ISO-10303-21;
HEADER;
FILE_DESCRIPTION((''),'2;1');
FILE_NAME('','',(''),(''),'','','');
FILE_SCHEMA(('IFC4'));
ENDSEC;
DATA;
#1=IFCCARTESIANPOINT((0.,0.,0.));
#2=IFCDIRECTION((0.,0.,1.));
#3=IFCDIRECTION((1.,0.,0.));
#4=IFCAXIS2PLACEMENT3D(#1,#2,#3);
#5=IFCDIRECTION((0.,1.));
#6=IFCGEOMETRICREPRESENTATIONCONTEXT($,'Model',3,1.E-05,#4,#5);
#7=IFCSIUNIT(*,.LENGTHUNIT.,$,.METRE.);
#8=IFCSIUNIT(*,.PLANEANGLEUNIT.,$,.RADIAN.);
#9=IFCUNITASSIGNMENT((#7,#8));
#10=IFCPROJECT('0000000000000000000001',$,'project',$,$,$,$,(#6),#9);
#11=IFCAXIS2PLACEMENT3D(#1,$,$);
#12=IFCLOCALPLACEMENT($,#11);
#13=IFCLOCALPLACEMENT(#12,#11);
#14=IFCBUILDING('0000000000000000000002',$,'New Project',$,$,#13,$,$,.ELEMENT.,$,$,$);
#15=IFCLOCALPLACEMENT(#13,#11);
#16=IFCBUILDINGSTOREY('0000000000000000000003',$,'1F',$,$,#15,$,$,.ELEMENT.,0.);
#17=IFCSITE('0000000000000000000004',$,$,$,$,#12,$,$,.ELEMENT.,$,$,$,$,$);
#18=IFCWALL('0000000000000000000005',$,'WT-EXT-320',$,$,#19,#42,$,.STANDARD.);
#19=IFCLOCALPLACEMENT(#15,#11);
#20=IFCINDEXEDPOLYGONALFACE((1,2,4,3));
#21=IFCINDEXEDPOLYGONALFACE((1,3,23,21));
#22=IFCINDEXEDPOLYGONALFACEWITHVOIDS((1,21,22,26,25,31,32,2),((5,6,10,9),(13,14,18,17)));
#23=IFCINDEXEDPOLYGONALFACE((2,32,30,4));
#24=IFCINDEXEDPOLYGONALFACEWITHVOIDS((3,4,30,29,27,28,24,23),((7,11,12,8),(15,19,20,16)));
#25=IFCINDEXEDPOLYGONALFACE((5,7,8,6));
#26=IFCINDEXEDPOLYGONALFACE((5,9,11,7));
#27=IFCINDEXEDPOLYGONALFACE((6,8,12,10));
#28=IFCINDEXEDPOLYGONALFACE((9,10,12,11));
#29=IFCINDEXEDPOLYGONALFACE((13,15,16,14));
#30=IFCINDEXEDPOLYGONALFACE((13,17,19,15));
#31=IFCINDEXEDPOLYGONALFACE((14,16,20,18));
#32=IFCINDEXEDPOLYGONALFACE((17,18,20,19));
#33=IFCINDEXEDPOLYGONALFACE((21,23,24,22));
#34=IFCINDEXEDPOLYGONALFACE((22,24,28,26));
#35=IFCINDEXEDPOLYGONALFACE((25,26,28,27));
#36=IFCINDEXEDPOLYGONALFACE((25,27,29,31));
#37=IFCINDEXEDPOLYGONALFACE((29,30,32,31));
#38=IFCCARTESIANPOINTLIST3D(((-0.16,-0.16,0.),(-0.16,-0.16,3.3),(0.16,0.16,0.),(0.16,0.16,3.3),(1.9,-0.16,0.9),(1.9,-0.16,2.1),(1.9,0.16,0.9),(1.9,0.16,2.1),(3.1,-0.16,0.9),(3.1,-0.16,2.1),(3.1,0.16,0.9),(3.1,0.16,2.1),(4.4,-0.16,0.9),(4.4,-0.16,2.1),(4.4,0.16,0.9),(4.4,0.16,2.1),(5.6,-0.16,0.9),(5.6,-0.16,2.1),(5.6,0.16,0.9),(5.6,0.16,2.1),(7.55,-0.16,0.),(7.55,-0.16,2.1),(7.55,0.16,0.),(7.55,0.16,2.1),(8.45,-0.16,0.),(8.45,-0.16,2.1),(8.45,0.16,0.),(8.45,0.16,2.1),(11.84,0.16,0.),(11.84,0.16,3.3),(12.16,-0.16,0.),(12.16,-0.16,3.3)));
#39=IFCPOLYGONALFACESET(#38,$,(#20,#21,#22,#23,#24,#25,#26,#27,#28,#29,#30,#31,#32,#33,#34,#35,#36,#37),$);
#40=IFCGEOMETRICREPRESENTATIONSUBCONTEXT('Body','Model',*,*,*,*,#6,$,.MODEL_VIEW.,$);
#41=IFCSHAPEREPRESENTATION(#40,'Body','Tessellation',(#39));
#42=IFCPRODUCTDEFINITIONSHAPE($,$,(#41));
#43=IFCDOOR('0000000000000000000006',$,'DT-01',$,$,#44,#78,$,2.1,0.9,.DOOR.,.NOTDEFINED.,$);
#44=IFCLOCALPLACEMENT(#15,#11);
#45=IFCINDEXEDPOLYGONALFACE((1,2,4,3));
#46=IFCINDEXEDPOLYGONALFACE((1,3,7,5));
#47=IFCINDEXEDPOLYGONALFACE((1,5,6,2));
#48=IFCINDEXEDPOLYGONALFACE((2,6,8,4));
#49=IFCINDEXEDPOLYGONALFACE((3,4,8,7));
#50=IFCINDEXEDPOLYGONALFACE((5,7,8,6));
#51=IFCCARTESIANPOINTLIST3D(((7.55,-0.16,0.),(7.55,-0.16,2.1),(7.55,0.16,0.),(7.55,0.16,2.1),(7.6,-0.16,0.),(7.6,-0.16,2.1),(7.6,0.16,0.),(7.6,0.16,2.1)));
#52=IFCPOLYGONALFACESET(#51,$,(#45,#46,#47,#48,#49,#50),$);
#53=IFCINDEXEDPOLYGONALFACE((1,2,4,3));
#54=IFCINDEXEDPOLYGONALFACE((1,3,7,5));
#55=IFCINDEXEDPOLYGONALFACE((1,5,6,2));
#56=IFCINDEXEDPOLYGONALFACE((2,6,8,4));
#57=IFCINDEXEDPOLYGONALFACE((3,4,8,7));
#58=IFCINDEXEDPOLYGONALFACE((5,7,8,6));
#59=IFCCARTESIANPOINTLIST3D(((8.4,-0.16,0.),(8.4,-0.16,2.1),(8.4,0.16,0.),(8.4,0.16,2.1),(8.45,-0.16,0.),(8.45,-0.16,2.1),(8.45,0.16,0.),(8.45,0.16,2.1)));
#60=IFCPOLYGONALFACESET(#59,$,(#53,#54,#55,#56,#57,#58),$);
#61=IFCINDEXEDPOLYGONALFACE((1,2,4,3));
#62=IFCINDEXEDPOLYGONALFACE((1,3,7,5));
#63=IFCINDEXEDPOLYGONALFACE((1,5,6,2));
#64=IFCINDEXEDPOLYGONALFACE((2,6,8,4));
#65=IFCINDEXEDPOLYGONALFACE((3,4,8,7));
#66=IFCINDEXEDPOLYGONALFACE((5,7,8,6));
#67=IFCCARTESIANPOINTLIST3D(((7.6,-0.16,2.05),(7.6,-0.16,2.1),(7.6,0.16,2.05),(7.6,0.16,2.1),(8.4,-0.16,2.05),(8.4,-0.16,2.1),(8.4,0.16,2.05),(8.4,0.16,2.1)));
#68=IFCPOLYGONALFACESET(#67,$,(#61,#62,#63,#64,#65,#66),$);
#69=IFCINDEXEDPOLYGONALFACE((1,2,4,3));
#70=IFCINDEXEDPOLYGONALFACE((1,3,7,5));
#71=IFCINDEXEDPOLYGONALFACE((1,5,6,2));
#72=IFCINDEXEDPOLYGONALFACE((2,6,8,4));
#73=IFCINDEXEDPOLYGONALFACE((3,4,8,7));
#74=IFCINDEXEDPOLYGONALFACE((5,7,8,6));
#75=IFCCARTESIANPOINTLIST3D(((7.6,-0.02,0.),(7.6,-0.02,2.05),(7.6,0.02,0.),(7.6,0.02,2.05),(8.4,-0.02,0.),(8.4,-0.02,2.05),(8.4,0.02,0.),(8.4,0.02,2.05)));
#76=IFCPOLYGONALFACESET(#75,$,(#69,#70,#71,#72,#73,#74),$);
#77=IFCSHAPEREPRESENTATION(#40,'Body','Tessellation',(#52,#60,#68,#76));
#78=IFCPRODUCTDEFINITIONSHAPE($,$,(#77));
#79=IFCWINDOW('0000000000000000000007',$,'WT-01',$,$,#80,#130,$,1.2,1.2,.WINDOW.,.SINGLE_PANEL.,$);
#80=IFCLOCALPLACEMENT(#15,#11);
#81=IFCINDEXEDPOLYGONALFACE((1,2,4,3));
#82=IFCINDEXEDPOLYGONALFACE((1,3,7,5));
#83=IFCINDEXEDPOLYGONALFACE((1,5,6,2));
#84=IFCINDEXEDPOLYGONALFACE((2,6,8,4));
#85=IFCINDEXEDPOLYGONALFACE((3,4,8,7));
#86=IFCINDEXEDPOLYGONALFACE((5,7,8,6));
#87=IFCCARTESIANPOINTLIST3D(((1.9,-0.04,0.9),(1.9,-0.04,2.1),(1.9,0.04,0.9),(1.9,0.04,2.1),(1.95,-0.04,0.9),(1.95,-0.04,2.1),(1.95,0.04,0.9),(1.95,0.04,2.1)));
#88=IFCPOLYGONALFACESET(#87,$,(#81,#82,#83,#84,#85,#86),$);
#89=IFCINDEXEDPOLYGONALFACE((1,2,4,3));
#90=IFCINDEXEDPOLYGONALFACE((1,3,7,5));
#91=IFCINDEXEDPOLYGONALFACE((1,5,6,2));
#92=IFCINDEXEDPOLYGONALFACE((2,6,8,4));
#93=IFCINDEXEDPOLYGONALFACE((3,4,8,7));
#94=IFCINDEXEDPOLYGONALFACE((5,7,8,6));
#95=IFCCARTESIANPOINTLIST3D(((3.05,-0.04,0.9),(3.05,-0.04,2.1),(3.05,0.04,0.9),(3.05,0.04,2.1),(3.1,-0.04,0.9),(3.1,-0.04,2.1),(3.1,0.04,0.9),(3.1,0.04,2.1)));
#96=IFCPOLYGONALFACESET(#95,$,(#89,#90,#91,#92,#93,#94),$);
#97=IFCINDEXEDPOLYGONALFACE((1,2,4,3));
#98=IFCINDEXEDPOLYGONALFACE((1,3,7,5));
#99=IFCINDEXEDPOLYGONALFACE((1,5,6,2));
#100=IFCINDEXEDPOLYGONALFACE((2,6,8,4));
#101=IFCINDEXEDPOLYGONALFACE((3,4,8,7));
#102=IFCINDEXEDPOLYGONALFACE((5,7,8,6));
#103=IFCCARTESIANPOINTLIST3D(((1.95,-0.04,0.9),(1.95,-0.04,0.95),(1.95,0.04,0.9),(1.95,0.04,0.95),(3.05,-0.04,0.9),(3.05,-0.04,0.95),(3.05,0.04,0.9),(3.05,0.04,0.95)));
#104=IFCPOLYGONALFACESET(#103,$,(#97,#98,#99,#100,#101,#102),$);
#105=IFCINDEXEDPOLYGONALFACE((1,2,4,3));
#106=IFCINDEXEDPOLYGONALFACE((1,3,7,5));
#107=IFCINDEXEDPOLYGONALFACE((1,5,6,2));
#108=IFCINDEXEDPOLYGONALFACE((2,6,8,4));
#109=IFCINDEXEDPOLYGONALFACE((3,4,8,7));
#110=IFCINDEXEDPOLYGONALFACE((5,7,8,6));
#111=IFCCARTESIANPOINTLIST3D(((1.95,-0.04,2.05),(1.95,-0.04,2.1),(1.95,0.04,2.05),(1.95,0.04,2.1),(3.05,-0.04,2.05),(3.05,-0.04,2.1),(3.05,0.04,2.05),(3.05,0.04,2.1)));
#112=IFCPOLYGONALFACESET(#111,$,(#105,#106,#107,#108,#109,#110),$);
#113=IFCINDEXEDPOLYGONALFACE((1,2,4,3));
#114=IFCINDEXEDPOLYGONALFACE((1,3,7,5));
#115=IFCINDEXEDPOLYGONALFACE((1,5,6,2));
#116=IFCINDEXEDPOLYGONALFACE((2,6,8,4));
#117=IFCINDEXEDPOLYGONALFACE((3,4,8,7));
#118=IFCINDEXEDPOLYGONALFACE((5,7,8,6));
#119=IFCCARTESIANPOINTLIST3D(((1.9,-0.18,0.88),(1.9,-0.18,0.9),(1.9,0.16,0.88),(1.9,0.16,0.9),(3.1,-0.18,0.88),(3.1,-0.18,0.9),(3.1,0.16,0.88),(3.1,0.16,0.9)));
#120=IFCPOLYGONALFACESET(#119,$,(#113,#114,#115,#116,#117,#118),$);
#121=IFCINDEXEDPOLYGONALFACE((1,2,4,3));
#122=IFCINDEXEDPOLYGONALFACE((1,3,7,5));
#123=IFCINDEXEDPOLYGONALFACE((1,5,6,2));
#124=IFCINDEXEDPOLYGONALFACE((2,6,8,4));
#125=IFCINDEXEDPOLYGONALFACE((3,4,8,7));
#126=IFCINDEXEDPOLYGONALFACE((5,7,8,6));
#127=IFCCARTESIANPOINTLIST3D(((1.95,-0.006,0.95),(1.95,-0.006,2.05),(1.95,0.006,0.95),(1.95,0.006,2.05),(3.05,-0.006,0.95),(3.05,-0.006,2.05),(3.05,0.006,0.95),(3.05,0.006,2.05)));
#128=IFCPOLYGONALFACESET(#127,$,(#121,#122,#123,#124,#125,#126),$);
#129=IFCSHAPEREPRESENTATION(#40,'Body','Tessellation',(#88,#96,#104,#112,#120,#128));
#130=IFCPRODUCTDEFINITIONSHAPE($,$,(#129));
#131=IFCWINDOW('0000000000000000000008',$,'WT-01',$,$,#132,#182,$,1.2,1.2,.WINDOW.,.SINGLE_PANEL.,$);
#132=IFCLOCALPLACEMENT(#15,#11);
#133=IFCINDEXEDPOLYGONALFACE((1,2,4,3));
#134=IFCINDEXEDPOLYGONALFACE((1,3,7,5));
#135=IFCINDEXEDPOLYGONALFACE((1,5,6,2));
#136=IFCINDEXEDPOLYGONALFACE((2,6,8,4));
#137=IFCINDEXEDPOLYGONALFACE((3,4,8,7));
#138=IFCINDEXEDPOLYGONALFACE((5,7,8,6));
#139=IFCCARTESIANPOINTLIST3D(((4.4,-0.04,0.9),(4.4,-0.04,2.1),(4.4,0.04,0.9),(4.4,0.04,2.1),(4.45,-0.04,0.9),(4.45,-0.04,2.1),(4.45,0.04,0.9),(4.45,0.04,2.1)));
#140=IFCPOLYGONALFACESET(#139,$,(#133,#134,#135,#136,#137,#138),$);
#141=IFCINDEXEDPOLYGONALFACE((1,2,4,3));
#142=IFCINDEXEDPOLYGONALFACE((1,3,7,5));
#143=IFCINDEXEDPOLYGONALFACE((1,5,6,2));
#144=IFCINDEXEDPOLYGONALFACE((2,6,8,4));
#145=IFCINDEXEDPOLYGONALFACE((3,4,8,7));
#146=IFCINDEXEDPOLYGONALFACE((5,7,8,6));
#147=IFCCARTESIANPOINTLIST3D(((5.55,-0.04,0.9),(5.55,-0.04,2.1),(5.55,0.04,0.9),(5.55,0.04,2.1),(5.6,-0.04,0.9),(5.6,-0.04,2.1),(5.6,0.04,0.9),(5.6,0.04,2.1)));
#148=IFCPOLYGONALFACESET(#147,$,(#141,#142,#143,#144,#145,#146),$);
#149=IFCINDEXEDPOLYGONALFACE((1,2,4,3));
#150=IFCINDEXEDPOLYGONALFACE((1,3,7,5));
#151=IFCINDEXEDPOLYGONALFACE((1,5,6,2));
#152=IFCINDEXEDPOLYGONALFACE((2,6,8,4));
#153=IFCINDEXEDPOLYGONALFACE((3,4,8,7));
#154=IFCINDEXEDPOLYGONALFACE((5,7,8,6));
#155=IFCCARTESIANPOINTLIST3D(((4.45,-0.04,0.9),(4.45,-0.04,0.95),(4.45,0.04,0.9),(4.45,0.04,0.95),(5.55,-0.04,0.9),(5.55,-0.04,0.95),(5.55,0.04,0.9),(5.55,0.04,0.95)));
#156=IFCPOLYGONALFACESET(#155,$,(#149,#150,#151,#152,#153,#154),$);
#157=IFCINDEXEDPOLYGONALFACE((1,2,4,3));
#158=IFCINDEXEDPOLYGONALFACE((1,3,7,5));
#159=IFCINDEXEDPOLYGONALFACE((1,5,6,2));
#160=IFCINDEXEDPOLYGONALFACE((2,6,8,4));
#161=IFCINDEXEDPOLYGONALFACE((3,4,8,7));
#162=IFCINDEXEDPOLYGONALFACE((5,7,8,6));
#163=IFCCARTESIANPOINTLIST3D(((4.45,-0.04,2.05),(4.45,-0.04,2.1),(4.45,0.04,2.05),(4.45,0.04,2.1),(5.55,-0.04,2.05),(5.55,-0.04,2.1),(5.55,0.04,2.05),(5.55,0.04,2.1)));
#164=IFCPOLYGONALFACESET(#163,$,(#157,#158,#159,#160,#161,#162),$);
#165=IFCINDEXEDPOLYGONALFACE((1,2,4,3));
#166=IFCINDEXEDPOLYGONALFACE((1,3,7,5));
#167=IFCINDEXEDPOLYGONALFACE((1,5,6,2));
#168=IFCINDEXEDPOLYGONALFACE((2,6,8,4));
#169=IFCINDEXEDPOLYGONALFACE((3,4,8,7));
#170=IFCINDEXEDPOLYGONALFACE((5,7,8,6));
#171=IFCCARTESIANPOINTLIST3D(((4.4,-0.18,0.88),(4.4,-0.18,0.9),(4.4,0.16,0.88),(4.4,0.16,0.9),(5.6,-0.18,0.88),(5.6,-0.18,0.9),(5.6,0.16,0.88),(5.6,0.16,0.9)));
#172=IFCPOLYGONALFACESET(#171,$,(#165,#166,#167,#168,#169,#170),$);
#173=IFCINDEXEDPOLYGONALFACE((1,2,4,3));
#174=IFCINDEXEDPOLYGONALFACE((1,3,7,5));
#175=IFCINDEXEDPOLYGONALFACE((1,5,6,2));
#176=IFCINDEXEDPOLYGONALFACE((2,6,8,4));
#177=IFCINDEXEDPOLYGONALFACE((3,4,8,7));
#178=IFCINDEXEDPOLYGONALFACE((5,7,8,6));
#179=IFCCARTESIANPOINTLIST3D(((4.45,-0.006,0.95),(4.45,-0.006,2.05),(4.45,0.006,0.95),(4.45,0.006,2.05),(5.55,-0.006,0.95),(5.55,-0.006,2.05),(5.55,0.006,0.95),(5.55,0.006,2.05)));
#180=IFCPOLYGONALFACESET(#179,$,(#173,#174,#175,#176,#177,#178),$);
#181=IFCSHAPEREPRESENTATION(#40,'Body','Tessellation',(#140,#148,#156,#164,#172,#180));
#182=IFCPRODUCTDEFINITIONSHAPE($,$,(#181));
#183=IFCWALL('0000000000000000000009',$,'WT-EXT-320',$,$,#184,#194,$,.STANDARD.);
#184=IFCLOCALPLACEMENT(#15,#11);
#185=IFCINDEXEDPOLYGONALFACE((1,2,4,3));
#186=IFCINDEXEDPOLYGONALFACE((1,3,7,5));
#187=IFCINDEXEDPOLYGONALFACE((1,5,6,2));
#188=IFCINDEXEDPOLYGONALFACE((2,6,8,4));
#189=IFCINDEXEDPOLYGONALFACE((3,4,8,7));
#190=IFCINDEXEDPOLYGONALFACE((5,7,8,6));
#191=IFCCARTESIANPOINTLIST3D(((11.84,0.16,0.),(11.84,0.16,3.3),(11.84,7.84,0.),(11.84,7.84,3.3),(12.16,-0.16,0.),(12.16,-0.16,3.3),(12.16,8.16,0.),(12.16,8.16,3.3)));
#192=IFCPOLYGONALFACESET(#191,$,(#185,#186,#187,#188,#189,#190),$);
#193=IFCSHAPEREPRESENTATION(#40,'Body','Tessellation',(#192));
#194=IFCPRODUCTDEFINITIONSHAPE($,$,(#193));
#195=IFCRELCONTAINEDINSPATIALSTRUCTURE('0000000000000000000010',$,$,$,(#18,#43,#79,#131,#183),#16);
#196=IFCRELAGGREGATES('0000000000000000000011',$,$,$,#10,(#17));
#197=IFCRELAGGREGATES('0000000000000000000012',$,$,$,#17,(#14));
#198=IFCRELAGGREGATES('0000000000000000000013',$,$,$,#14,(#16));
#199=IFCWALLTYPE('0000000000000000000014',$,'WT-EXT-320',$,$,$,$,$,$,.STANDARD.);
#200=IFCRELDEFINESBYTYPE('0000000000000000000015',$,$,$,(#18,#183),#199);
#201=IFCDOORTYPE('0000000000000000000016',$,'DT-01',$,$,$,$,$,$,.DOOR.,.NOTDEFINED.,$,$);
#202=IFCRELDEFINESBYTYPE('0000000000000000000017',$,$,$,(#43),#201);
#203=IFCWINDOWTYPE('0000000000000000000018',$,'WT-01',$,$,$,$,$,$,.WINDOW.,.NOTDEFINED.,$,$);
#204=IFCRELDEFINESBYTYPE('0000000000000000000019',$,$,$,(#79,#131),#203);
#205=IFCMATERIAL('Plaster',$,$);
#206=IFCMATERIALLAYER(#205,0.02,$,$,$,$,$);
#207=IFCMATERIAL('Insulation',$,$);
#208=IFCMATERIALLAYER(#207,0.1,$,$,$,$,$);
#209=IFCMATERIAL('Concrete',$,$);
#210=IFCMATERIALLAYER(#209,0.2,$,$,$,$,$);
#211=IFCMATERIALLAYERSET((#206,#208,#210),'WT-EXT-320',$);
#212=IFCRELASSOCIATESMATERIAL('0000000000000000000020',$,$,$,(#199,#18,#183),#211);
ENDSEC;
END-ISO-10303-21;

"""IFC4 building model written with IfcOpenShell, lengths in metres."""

from ifc_helpers import new_model, si_unit, direction, frame, frame_2d, origin, origin_with_axes, place, context, subcontext, project, spatial, polyline, rectangle, outline, extrude, material, layer, layer_set, layer_usage, type_object, element, fill, save


model = new_model("IFC4")

# Units and contexts
model_context = context("Model", 3, precision=1e-05, world=origin_with_axes(), true_north=direction((0.0, 1.0)))
body_context = subcontext(model_context, "Body", "Model", "MODEL_VIEW")
ifc_project = project(units=[si_unit("LENGTHUNIT", "METRE"), si_unit("PLANEANGLEUNIT", "RADIAN")], contexts=[model_context])

# Site, building, storey
site_placement = place(None, origin())
site = spatial("IfcSite", under=ifc_project, at=site_placement, CompositionType="ELEMENT")
building_placement = place(site_placement, origin())
building = spatial("IfcBuilding", under=site, at=building_placement, Name="New Project", CompositionType="ELEMENT")
storey_placement = place(building_placement, origin())
storey = spatial("IfcBuildingStorey", under=building, at=storey_placement, Name="1F", CompositionType="ELEMENT", Elevation=0.0)

# Shared definitions
ifc_material_1 = material(Name="Concrete")

# Wall, openings, door, windows
ifc_material_2 = material(Name="Plaster")
ifc_layer_1 = layer(ifc_material_2, 0.02)
ifc_material_3 = material(Name="Insulation")
ifc_layer_2 = layer(ifc_material_3, 0.1)
ifc_layer_3 = layer(ifc_material_1, 0.2)
ifc_layer_set_1 = layer_set([ifc_layer_1, ifc_layer_2, ifc_layer_3], Name="WT-EXT-320")
ifc_layer_usage_1 = layer_usage(ifc_layer_set_1, "AXIS2", "NEGATIVE", 0.16)
wall_type_1 = type_object("IfcWallType", Name="WT-EXT-320", PredefinedType="STANDARD", material=ifc_layer_set_1)
wall_1_placement = place(storey_placement, origin())
wall_1 = element("IfcWall", 1, at=wall_1_placement, inside=storey, type_object=wall_type_1, material=ifc_layer_usage_1, Name="WT-EXT-320", PredefinedType="STANDARD", context=body_context, shape_type="SweptSolid", body=[
    extrude(outline(polyline([(-0.16, -0.16), (12.16, -0.16), (11.84, 0.16), (0.16, 0.16), (-0.16, -0.16)])), origin(), (0.0, 0.0, 1.0), 3.3),
])
opening_1_placement = place(wall_1_placement, frame((7.55, 0.0, 0.0)))
opening_1 = element("IfcOpeningElement", 2, at=opening_1_placement, cuts=wall_1, PredefinedType="OPENING", context=body_context, shape_type="SweptSolid", body=[
    extrude(rectangle(XDim=0.9, YDim=0.42, at=frame_2d((0.45, 0.0))), origin(), (0.0, 0.0, 1.0), 2.1),
])
opening_2_placement = place(wall_1_placement, frame((1.9, 0.0, 0.9)))
opening_2 = element("IfcOpeningElement", 3, at=opening_2_placement, cuts=wall_1, PredefinedType="OPENING", context=body_context, shape_type="SweptSolid", body=[
    extrude(rectangle(XDim=1.2, YDim=0.42, at=frame_2d((0.6, 0.0))), origin(), (0.0, 0.0, 1.0), 1.2),
])
opening_3_placement = place(wall_1_placement, frame((4.4, 0.0, 0.9)))
opening_3 = element("IfcOpeningElement", 4, at=opening_3_placement, cuts=wall_1, PredefinedType="OPENING", context=body_context, shape_type="SweptSolid", body=[
    extrude(rectangle(XDim=1.2, YDim=0.42, at=frame_2d((0.6, 0.0))), origin(), (0.0, 0.0, 1.0), 1.2),
])
door_type_1 = type_object("IfcDoorType", Name="DT-01", OperationType="NOTDEFINED", PredefinedType="DOOR")
door_1_placement = place(opening_1_placement, origin())
door_1 = element("IfcDoor", 5, at=door_1_placement, inside=storey, type_object=door_type_1, Name="DT-01", OperationType="NOTDEFINED", OverallHeight=2.1, OverallWidth=0.9, PredefinedType="DOOR", context=body_context, shape_type="SweptSolid", body=[
    extrude(outline(polyline([(0.0, -0.16), (0.05, -0.16), (0.05, 0.16), (0.0, 0.16), (0.0, -0.16)])), origin(), (0.0, 0.0, 1.0), 2.1),
    extrude(outline(polyline([(0.85, -0.16), (0.9, -0.16), (0.9, 0.16), (0.85, 0.16), (0.85, -0.16)])), origin(), (0.0, 0.0, 1.0), 2.1),
    extrude(outline(polyline([(0.05, -0.16), (0.85, -0.16), (0.85, 0.16), (0.05, 0.16), (0.05, -0.16)])), frame((0.0, 0.0, 2.05)), (0.0, 0.0, 1.0), 0.05),
    extrude(outline(polyline([(0.05, -0.02), (0.85, -0.02), (0.85, 0.02), (0.05, 0.02), (0.05, -0.02)])), origin(), (0.0, 0.0, 1.0), 2.05),
])
fill(opening_1, door_1)
window_type_1 = type_object("IfcWindowType", Name="WT-01", PartitioningType="NOTDEFINED", PredefinedType="WINDOW")
window_1_placement = place(opening_2_placement, origin())
window_1 = element("IfcWindow", 6, at=window_1_placement, inside=storey, type_object=window_type_1, Name="WT-01", OverallHeight=1.2, OverallWidth=1.2, PartitioningType="SINGLE_PANEL", PredefinedType="WINDOW", context=body_context, shape_type="SweptSolid", body=[
    extrude(outline(polyline([(0.0, -0.04), (0.05, -0.04), (0.05, 0.04), (0.0, 0.04), (0.0, -0.04)])), origin(), (0.0, 0.0, 1.0), 1.2),
    extrude(outline(polyline([(1.15, -0.04), (1.2, -0.04), (1.2, 0.04), (1.15, 0.04), (1.15, -0.04)])), origin(), (0.0, 0.0, 1.0), 1.2),
    extrude(outline(polyline([(0.05, -0.04), (1.15, -0.04), (1.15, 0.04), (0.05, 0.04), (0.05, -0.04)])), origin(), (0.0, 0.0, 1.0), 0.05),
    extrude(outline(polyline([(0.05, -0.04), (1.15, -0.04), (1.15, 0.04), (0.05, 0.04), (0.05, -0.04)])), frame((0.0, 0.0, 1.15)), (0.0, 0.0, 1.0), 0.05),
    extrude(outline(polyline([(0.0, -0.18), (1.2, -0.18), (1.2, 0.16), (0.0, 0.16), (0.0, -0.18)])), frame((0.0, 0.0, -0.02)), (0.0, 0.0, 1.0), 0.02),
    extrude(outline(polyline([(0.05, -0.006), (1.15, -0.006), (1.15, 0.006), (0.05, 0.006), (0.05, -0.006)])), frame((0.0, 0.0, 0.05)), (0.0, 0.0, 1.0), 1.1),
])
fill(opening_2, window_1)
window_2_placement = place(opening_3_placement, origin())
window_2 = element("IfcWindow", 7, at=window_2_placement, inside=storey, type_object=window_type_1, Name="WT-01", OverallHeight=1.2, OverallWidth=1.2, PartitioningType="SINGLE_PANEL", PredefinedType="WINDOW", context=body_context, shape_type="SweptSolid", body=[
    extrude(outline(polyline([(0.0, -0.04), (0.05, -0.04), (0.05, 0.04), (0.0, 0.04), (0.0, -0.04)])), origin(), (0.0, 0.0, 1.0), 1.2),
    extrude(outline(polyline([(1.15, -0.04), (1.2, -0.04), (1.2, 0.04), (1.15, 0.04), (1.15, -0.04)])), origin(), (0.0, 0.0, 1.0), 1.2),
    extrude(outline(polyline([(0.05, -0.04), (1.15, -0.04), (1.15, 0.04), (0.05, 0.04), (0.05, -0.04)])), origin(), (0.0, 0.0, 1.0), 0.05),
    extrude(outline(polyline([(0.05, -0.04), (1.15, -0.04), (1.15, 0.04), (0.05, 0.04), (0.05, -0.04)])), frame((0.0, 0.0, 1.15)), (0.0, 0.0, 1.0), 0.05),
    extrude(outline(polyline([(0.0, -0.18), (1.2, -0.18), (1.2, 0.16), (0.0, 0.16), (0.0, -0.18)])), frame((0.0, 0.0, -0.02)), (0.0, 0.0, 1.0), 0.02),
    extrude(outline(polyline([(0.05, -0.006), (1.15, -0.006), (1.15, 0.006), (0.05, 0.006), (0.05, -0.006)])), frame((0.0, 0.0, 0.05)), (0.0, 0.0, 1.0), 1.1),
])
fill(opening_3, window_2)

# Wall
wall_2_placement = place(storey_placement, frame((12.0, 0.0, 0.0), z_axis=(0.0, 0.0, 1.0), x_axis=(0.0, 1.0, 0.0)))
element("IfcWall", 8, at=wall_2_placement, inside=storey, type_object=wall_type_1, material=ifc_layer_usage_1, Name="WT-EXT-320", PredefinedType="STANDARD", context=body_context, shape_type="SweptSolid", body=[
    extrude(outline(polyline([(-0.16, -0.16), (8.16, -0.16), (7.84, 0.16), (0.16, 0.16), (-0.16, -0.16)])), origin(), (0.0, 0.0, 1.0), 3.3),
])

save(model, "model.ifc")
